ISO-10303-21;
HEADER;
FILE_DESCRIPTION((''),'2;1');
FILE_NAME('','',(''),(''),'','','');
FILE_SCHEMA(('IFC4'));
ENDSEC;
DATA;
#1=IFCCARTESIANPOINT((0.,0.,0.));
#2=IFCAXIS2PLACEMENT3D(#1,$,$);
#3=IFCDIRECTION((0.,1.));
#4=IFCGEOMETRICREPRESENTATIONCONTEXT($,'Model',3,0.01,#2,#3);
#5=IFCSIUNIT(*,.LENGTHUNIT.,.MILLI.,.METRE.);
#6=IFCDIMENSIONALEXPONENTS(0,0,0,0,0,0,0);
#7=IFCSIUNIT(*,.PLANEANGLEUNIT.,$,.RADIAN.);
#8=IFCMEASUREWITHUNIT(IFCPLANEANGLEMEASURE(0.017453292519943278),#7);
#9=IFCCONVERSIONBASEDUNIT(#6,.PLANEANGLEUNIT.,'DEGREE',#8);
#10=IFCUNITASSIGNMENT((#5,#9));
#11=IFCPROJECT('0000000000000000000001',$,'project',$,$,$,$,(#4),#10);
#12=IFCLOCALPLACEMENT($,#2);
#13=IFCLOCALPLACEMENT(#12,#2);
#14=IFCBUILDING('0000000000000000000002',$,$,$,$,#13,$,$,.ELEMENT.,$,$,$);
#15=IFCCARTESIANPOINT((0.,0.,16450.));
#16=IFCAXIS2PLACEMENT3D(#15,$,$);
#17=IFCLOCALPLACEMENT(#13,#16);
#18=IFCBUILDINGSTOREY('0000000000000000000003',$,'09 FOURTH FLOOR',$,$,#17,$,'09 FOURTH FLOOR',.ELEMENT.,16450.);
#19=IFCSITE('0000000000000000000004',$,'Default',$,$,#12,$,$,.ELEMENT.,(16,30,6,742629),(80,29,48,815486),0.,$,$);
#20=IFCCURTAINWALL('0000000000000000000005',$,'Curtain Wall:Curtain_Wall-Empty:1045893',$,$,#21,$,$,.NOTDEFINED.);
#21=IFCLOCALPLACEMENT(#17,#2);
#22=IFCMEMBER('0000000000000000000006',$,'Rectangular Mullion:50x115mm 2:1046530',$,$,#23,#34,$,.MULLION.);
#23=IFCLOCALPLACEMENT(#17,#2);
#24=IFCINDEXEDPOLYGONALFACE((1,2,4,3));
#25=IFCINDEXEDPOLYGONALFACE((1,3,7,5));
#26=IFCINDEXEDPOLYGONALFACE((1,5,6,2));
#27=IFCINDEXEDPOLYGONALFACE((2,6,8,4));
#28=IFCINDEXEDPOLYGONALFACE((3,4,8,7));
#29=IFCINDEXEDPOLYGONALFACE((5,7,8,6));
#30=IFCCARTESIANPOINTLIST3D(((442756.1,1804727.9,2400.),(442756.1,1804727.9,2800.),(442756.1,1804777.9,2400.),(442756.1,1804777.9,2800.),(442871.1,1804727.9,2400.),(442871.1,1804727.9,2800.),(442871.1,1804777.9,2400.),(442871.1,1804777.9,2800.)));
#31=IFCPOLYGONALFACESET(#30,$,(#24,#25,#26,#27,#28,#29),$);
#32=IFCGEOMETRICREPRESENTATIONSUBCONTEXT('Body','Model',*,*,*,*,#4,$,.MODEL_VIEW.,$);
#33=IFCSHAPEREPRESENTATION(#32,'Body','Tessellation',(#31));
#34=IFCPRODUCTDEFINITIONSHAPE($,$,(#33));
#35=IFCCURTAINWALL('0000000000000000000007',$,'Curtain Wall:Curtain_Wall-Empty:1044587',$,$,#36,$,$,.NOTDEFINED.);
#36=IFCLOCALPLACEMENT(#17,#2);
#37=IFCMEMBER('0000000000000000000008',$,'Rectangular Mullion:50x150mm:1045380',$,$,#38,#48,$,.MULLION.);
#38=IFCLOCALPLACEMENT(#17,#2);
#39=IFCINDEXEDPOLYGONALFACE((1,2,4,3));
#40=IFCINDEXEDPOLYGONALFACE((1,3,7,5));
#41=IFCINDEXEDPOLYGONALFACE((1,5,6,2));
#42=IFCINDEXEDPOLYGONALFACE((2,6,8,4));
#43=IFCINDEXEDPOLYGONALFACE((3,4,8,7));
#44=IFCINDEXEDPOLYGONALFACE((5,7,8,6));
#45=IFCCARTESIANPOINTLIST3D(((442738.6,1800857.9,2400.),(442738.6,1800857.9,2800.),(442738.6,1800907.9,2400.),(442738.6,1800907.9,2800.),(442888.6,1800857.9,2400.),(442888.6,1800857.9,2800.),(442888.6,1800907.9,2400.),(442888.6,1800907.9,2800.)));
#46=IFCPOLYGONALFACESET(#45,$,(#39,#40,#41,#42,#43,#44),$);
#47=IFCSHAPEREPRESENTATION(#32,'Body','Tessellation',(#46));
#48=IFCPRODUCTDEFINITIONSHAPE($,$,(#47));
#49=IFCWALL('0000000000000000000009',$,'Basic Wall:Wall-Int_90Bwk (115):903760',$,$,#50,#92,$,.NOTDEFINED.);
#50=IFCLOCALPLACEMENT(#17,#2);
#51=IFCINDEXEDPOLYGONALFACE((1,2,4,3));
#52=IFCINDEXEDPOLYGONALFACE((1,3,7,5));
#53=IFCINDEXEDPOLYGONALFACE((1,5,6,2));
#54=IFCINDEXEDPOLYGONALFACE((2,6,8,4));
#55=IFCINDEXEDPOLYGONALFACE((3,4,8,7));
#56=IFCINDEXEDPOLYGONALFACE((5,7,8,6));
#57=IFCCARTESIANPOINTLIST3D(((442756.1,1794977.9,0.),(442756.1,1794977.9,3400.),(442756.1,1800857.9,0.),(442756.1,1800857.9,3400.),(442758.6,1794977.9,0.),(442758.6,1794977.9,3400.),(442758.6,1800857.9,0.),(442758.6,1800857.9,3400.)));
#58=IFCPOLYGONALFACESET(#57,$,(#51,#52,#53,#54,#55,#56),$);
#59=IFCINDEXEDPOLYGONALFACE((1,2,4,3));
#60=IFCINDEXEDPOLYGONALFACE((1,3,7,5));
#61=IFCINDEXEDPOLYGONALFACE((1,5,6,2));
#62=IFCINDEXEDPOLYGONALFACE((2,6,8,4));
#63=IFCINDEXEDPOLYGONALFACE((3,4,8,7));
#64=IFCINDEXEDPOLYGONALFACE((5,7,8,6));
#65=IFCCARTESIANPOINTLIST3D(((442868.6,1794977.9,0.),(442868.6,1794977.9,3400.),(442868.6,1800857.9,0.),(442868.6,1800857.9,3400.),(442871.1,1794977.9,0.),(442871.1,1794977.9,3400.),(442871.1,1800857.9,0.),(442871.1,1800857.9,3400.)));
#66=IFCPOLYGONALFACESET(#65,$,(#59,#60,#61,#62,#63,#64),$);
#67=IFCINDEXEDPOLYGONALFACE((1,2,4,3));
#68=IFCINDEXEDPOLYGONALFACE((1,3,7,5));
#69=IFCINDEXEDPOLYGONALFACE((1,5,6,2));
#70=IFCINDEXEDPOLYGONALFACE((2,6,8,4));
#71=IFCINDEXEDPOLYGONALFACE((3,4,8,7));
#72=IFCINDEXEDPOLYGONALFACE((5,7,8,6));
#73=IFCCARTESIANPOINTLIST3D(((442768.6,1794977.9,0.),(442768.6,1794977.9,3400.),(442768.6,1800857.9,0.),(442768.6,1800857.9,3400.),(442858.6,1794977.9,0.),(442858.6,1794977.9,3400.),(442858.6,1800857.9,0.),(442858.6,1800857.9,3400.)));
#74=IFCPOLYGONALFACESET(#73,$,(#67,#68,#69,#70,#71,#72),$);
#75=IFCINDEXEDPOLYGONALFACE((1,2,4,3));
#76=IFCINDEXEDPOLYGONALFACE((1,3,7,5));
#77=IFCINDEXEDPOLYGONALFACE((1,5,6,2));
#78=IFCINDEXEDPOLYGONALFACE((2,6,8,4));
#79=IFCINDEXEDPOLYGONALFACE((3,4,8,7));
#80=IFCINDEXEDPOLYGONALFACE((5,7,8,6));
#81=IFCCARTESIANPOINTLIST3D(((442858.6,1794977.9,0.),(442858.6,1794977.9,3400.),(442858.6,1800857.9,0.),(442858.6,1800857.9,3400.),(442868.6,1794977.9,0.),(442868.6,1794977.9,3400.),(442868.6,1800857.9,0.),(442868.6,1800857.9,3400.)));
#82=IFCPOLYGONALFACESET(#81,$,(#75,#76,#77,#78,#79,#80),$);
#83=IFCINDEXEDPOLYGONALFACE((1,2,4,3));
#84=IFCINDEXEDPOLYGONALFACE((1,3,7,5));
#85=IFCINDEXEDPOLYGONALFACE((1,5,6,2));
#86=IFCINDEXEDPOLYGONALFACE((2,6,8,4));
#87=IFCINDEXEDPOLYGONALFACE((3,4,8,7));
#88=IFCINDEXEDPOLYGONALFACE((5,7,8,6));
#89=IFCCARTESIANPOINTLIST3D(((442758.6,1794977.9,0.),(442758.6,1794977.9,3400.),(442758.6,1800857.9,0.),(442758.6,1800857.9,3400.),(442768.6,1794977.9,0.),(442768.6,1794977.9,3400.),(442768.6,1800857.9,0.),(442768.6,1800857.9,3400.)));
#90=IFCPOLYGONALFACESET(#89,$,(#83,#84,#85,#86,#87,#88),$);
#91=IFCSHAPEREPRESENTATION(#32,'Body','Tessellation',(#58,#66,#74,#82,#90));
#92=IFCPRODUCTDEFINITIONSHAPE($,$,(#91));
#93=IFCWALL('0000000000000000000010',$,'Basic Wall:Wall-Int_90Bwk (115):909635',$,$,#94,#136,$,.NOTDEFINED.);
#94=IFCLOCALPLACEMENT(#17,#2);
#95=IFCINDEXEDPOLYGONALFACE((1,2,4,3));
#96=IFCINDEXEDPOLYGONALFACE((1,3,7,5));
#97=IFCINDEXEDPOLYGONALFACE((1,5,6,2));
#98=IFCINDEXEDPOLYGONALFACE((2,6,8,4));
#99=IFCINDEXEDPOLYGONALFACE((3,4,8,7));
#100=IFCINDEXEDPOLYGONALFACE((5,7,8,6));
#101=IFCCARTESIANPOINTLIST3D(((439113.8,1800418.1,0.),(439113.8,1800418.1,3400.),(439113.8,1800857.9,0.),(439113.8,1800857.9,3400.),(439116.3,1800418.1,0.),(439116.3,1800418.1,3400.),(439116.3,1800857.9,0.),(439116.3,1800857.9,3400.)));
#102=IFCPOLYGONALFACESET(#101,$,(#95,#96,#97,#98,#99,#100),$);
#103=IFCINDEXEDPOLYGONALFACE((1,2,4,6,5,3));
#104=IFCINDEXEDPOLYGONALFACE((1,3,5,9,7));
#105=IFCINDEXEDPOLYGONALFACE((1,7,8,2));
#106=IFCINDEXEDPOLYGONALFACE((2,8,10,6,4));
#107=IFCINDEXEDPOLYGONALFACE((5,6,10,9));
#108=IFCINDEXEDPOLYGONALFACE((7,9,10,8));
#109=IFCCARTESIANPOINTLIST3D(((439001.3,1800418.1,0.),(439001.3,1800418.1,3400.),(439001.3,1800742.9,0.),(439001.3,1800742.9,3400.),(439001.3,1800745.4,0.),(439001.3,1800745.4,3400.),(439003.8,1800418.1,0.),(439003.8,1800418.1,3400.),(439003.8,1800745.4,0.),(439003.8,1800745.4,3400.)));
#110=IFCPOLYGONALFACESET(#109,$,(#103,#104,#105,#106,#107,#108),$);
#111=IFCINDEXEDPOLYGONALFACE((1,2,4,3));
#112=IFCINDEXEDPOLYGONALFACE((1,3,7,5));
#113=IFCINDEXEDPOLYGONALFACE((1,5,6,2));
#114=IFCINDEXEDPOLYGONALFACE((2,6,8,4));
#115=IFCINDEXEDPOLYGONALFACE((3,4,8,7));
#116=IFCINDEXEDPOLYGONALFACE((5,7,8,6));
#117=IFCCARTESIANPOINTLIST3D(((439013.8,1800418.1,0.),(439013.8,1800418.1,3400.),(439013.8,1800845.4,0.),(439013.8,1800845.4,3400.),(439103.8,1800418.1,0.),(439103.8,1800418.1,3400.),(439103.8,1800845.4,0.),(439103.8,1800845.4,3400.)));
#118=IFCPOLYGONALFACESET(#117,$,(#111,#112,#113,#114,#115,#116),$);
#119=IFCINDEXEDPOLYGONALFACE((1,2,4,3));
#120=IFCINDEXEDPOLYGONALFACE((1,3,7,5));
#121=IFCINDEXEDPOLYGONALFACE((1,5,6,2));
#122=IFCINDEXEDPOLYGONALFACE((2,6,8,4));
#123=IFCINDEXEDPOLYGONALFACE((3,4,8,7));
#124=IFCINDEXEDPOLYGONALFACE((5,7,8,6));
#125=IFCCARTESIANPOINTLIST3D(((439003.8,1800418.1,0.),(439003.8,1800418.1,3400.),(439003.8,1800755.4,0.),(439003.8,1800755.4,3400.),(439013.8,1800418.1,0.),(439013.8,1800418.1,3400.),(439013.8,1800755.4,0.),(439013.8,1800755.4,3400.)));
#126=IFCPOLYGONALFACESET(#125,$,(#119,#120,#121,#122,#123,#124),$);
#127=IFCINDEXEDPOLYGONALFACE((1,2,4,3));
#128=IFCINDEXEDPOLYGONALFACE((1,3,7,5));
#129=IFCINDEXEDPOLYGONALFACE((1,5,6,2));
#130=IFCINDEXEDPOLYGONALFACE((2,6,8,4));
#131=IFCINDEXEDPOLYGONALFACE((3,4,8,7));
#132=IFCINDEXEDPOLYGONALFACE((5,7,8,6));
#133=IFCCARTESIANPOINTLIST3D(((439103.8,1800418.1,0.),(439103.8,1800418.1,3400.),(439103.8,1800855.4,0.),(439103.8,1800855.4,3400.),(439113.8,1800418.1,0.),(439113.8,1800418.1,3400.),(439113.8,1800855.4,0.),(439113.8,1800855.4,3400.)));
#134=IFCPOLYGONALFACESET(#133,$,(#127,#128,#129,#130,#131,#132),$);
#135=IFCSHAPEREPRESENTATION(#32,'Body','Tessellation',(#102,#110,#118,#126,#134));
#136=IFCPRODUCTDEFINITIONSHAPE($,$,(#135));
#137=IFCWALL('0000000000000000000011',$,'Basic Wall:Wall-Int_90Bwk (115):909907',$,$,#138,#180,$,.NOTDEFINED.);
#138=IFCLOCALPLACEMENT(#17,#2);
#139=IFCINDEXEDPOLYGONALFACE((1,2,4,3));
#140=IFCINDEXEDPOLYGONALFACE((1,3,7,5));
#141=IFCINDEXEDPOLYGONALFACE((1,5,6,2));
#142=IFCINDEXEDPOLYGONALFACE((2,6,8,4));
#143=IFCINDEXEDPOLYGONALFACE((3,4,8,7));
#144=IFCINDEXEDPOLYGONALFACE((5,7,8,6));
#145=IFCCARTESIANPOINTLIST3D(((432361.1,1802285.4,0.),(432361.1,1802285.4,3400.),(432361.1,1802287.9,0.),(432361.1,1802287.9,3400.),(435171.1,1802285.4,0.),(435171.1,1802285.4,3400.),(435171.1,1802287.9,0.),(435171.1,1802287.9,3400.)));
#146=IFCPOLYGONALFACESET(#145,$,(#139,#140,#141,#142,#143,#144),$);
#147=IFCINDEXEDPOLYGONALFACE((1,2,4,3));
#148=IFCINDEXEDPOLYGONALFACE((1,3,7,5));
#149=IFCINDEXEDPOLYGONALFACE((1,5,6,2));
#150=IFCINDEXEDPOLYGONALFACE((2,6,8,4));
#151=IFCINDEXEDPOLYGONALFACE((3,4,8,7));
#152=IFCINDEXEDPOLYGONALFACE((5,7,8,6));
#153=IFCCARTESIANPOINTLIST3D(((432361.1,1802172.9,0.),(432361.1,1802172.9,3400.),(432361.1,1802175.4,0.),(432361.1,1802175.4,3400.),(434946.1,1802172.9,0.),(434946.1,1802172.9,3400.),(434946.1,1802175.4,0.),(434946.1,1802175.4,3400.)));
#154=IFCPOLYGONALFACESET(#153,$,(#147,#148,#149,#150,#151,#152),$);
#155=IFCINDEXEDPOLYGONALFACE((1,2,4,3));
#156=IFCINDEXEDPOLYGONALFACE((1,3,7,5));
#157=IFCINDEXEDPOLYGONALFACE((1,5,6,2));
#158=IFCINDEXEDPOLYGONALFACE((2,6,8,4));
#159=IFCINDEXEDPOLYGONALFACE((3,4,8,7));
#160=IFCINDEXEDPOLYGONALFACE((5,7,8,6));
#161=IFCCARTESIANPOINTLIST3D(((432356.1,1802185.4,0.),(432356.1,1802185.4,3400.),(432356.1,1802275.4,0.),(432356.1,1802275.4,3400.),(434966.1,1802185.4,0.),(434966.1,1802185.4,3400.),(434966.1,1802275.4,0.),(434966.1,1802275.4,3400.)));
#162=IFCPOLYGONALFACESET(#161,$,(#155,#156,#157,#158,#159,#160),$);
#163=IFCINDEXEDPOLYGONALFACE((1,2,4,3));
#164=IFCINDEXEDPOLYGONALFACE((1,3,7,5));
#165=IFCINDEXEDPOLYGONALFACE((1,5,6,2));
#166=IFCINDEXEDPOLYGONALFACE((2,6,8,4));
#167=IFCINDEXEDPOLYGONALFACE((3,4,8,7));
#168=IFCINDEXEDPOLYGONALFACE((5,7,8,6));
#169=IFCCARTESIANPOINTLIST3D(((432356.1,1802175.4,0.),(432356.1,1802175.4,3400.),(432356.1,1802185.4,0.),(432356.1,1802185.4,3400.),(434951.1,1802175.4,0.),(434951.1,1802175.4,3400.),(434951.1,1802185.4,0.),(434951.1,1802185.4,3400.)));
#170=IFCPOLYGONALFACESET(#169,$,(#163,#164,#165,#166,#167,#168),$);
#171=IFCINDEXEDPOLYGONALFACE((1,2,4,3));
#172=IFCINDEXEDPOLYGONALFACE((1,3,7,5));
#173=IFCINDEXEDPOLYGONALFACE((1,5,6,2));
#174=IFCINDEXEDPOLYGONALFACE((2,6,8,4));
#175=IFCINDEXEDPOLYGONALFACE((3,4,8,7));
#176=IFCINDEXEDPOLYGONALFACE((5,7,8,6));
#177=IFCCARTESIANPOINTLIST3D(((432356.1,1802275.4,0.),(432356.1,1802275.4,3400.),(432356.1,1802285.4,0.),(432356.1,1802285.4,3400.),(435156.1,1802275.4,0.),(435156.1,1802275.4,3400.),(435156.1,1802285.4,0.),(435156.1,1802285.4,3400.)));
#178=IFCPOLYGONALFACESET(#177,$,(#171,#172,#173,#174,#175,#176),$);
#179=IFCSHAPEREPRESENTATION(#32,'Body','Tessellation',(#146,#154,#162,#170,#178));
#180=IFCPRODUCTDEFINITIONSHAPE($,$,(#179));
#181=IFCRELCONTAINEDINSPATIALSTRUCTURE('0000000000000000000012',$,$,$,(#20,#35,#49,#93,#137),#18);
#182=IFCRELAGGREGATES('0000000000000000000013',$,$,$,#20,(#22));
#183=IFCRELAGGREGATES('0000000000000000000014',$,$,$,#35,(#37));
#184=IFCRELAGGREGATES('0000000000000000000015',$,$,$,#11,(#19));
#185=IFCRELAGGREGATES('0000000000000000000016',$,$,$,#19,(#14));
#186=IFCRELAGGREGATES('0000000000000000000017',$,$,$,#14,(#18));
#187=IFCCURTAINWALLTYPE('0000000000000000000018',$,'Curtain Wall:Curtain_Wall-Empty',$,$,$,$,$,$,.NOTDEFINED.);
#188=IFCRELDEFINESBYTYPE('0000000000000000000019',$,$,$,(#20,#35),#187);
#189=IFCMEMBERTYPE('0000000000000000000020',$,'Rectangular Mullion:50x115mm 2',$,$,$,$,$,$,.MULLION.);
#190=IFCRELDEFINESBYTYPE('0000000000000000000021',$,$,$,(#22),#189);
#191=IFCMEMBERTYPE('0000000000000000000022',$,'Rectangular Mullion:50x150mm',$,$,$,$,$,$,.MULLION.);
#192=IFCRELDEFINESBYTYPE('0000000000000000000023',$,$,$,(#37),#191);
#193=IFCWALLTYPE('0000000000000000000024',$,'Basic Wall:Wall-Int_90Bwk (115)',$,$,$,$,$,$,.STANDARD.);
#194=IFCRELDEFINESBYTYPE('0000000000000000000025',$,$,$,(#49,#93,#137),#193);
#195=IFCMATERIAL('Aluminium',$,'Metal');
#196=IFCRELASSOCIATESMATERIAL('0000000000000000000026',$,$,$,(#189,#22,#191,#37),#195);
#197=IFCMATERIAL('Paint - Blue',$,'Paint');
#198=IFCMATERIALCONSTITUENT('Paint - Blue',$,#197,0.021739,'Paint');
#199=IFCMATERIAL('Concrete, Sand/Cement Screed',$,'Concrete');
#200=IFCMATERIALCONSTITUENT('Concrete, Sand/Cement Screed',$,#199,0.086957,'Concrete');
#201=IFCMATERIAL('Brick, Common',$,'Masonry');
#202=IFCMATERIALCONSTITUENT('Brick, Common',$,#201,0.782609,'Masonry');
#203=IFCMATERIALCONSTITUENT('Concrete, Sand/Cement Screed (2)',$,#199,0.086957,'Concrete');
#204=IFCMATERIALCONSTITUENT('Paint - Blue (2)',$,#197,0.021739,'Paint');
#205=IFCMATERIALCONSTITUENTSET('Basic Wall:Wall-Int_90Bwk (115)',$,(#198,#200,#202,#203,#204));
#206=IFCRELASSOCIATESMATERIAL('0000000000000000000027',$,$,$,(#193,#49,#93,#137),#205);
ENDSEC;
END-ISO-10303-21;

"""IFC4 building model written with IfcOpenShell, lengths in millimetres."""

from ifc_helpers import new_model, entity, si_unit, converted_unit, direction, frame, origin, place, context, subcontext, project, spatial, indexed_curve, outline, extrude, source, transform, mapped, material, constituent, constituent_set, type_object, type_shapes, element, aggregate, save


model = new_model("IFC4")

# Units and contexts
model_context = context("Model", 3, precision=0.01, world=origin(), true_north=direction((0.0, 1.0)))
body_context = subcontext(model_context, "Body", "Model", "MODEL_VIEW")
ifc_project = project(units=[si_unit("LENGTHUNIT", "METRE", prefix="MILLI"), converted_unit("PLANEANGLEUNIT", "DEGREE", entity("IfcPlaneAngleMeasure", 0.017453292519943278), si_unit("PLANEANGLEUNIT", "RADIAN"), dimensions=[0, 0, 0, 0, 0, 0, 0])], contexts=[model_context])

# Site, building, storey
site_placement = place(None, origin())
site = spatial("IfcSite", under=ifc_project, at=site_placement, Name="Default", CompositionType="ELEMENT", RefLatitude=(16, 30, 6, 742629), RefLongitude=(80, 29, 48, 815486), RefElevation=0.0)
building_placement = place(site_placement, origin())
building = spatial("IfcBuilding", under=site, at=building_placement, CompositionType="ELEMENT")
storey_placement = place(building_placement, frame((0.0, 0.0, 16450.0)))
storey = spatial("IfcBuildingStorey", under=building, at=storey_placement, Name="09 FOURTH FLOOR", LongName="09 FOURTH FLOOR", CompositionType="ELEMENT", Elevation=16450.0)

# Curtain walls, members
curtain_wall_type = type_object("IfcCurtainWallType", Name="Curtain Wall:Curtain_Wall-Empty", PredefinedType="NOTDEFINED")
curtain_wall_1_placement = place(storey_placement, frame((0.0, 0.0, -16450.0)))
curtain_wall_1 = element("IfcCurtainWall", 1, at=curtain_wall_1_placement, inside=storey, type_object=curtain_wall_type, Name="Curtain Wall:Curtain_Wall-Empty:1045893", PredefinedType="NOTDEFINED")
ifc_material_1 = material(Name="Aluminium", Category="Metal")
member_type_1 = type_object("IfcMemberType", Name="Rectangular Mullion:50x115mm 2", PredefinedType="MULLION", material=ifc_material_1)
shared_shape_1 = source(origin(), body_context, "Body", "SweptSolid", [
    extrude(outline(indexed_curve([(-25.0, -57.5), (25.0, -57.5), (25.0, 57.5), (-25.0, 57.5), (-25.0, -57.5)], self_intersect=False)), frame((-25.0, 0.0, -400.0), z_axis=(0.0, 0.0, 1.0), x_axis=(-1.0, 0.0, 0.0)), (0.0, 0.0, 1.0), 400.0),
])
type_shapes(member_type_1, [shared_shape_1])
member_1_placement = place(curtain_wall_1_placement, frame((442813.6, 1804727.9, 19250.0), z_axis=(0.0, 0.0, 1.0), x_axis=(0.0, -1.0, 0.0)))
member_1 = element("IfcMember", 2, at=member_1_placement, type_object=member_type_1, material=ifc_material_1, Name="Rectangular Mullion:50x115mm 2:1046530", PredefinedType="MULLION", context=body_context, shape_type="MappedRepresentation", body=[
    mapped(shared_shape_1, transform((0.0, 0.0, 0.0), scale=1.0)),
])
aggregate(curtain_wall_1, [member_1])
curtain_wall_2_placement = place(storey_placement, frame((0.0, 0.0, -16450.0)))
curtain_wall_2 = element("IfcCurtainWall", 3, at=curtain_wall_2_placement, inside=storey, type_object=curtain_wall_type, Name="Curtain Wall:Curtain_Wall-Empty:1044587", PredefinedType="NOTDEFINED")
member_type_2 = type_object("IfcMemberType", Name="Rectangular Mullion:50x150mm", PredefinedType="MULLION", material=ifc_material_1)
shared_shape_2 = source(origin(), body_context, "Body", "SweptSolid", [
    extrude(outline(indexed_curve([(-25.0, -75.0), (25.0, -75.0), (25.0, 75.0), (-25.0, 75.0), (-25.0, -75.0)], self_intersect=False)), frame((-25.0, 0.0, -400.0), z_axis=(0.0, 0.0, 1.0), x_axis=(-1.0, 0.0, 0.0)), (0.0, 0.0, 1.0), 400.0),
])
type_shapes(member_type_2, [shared_shape_2])
member_2_placement = place(curtain_wall_2_placement, frame((442813.6, 1800857.9, 19250.0), z_axis=(0.0, 0.0, 1.0), x_axis=(0.0, -1.0, 0.0)))
member_2 = element("IfcMember", 4, at=member_2_placement, type_object=member_type_2, material=ifc_material_1, Name="Rectangular Mullion:50x150mm:1045380", PredefinedType="MULLION", context=body_context, shape_type="MappedRepresentation", body=[
    mapped(shared_shape_2, transform((0.0, 0.0, 0.0), scale=1.0)),
])
aggregate(curtain_wall_2, [member_2])

# Wall
ifc_material_2 = material(Name="Paint - Blue", Category="Paint")
ifc_constituent_1 = constituent(ifc_material_2, Name="Paint - Blue", Category="Paint", fraction=0.021739)
ifc_material_3 = material(Name="Concrete, Sand/Cement Screed", Category="Concrete")
ifc_constituent_2 = constituent(ifc_material_3, Name="Concrete, Sand/Cement Screed", Category="Concrete", fraction=0.086957)
ifc_material_4 = material(Name="Brick, Common", Category="Masonry")
ifc_constituent_3 = constituent(ifc_material_4, Name="Brick, Common", Category="Masonry", fraction=0.782609)
ifc_constituent_4 = constituent(ifc_material_3, Name="Concrete, Sand/Cement Screed (2)", Category="Concrete", fraction=0.086957)
ifc_constituent_5 = constituent(ifc_material_2, Name="Paint - Blue (2)", Category="Paint", fraction=0.021739)
ifc_constituent_set_1 = constituent_set(constituents=[ifc_constituent_1, ifc_constituent_2, ifc_constituent_3, ifc_constituent_4, ifc_constituent_5], Name="Basic Wall:Wall-Int_90Bwk (115)")
wall_type_1 = type_object("IfcWallType", Name="Basic Wall:Wall-Int_90Bwk (115)", PredefinedType="STANDARD", material=ifc_constituent_set_1)
wall_1_placement = place(storey_placement, frame((442813.6, 1794977.9, 0.0), z_axis=(0.0, 0.0, 1.0), x_axis=(0.0, 1.0, 0.0)))
element("IfcWall", 5, at=wall_1_placement, inside=storey, type_object=wall_type_1, material=ifc_constituent_set_1, Name="Basic Wall:Wall-Int_90Bwk (115):903760", PredefinedType="NOTDEFINED", context=body_context, shape_type="SweptSolid", body=[
    extrude(outline(indexed_curve([(-1.3, -2940.0), (1.2, -2940.0), (1.2, 2940.0), (-1.3, 2940.0), (-1.3, -2940.0)], self_intersect=False)), frame((2940.0, 56.2, 0.0), z_axis=(0.0, 0.0, 1.0), x_axis=(0.0, -1.0, 0.0)), (0.0, 0.0, 1.0), 3400.0),
    extrude(outline(indexed_curve([(-1.3, -2940.0), (1.2, -2940.0), (1.2, 2940.0), (-1.3, 2940.0), (-1.3, -2940.0)], self_intersect=False)), frame((2940.0, -56.2, 0.0), z_axis=(0.0, 0.0, 1.0), x_axis=(0.0, 1.0, 0.0)), (0.0, 0.0, 1.0), 3400.0),
    extrude(outline(indexed_curve([(-2940.0, -45.0), (2940.0, -45.0), (2940.0, 45.0), (-2940.0, 45.0), (-2940.0, -45.0)], self_intersect=False)), frame((2940.0, 0.0, 0.0)), (0.0, 0.0, 1.0), 3400.0),
    extrude(outline(indexed_curve([(-2940.0, -5.0), (2940.0, -5.0), (2940.0, 5.0), (-2940.0, 5.0), (-2940.0, -5.0)], self_intersect=False)), frame((2940.0, -50.0, 0.0)), (0.0, 0.0, 1.0), 3400.0),
    extrude(outline(indexed_curve([(-2940.0, -5.0), (2940.0, -5.0), (2940.0, 5.0), (-2940.0, 5.0), (-2940.0, -5.0)], self_intersect=False)), frame((2940.0, 50.0, 0.0)), (0.0, 0.0, 1.0), 3400.0),
])

# Wall
wall_2_placement = place(storey_placement, frame((439058.8, 1800418.1, 0.0), z_axis=(0.0, 0.0, 1.0), x_axis=(0.0, 1.0, 0.0)))
element("IfcWall", 6, at=wall_2_placement, inside=storey, type_object=wall_type_1, material=ifc_constituent_set_1, Name="Basic Wall:Wall-Int_90Bwk (115):909635", PredefinedType="NOTDEFINED", context=body_context, shape_type="SweptSolid", body=[
    extrude(outline(indexed_curve([(-1.3, -219.9), (1.2, -219.9), (1.2, 219.9), (-1.3, 219.9), (-1.3, -219.9)], self_intersect=False)), frame((219.9, -56.2, 0.0), z_axis=(0.0, 0.0, 1.0), x_axis=(0.0, 1.0, 0.0)), (0.0, 0.0, 1.0), 3400.0),
    extrude(outline(indexed_curve([(-128.9, -1.0), (195.9, -1.0), (195.9, 1.5), (-131.4, 1.5), (-131.4, -1.0), (-128.9, -1.0)], self_intersect=False)), frame((195.9, 56.5, 0.0), z_axis=(0.0, 0.0, 1.0), x_axis=(-1.0, 0.0, 0.0)), (0.0, 0.0, 1.0), 3400.0),
    extrude(outline(indexed_curve([(-213.7, -45.0), (213.7, -45.0), (213.7, 45.0), (-213.7, 45.0), (-213.7, -45.0)], self_intersect=False)), frame((213.7, 0.0, 0.0)), (0.0, 0.0, 1.0), 3400.0),
    extrude(outline(indexed_curve([(-168.7, -5.0), (168.7, -5.0), (168.7, 5.0), (-168.7, 5.0), (-168.7, -5.0)], self_intersect=False)), frame((168.7, 50.0, 0.0)), (0.0, 0.0, 1.0), 3400.0),
    extrude(outline(indexed_curve([(-218.7, -5.0), (218.7, -5.0), (218.7, 5.0), (-218.7, 5.0), (-218.7, -5.0)], self_intersect=False)), frame((218.7, -50.0, 0.0)), (0.0, 0.0, 1.0), 3400.0),
])

# Wall
wall_3_placement = place(storey_placement, frame((432361.1, 1802230.4, 0.0)))
element("IfcWall", 7, at=wall_3_placement, inside=storey, type_object=wall_type_1, material=ifc_constituent_set_1, Name="Basic Wall:Wall-Int_90Bwk (115):909907", PredefinedType="NOTDEFINED", context=body_context, shape_type="SweptSolid", body=[
    extrude(outline(indexed_curve([(-1.3, -1405.0), (1.3, -1405.0), (1.3, 1405.0), (-1.3, 1405.0), (-1.3, -1405.0)], self_intersect=False)), frame((1405.0, 56.3, 0.0), z_axis=(0.0, 0.0, 1.0), x_axis=(0.0, -1.0, 0.0)), (0.0, 0.0, 1.0), 3400.0),
    extrude(outline(indexed_curve([(-1.2, -1292.5), (1.3, -1292.5), (1.3, 1292.5), (-1.2, 1292.5), (-1.2, -1292.5)], self_intersect=False)), frame((1292.5, -56.3, 0.0), z_axis=(0.0, 0.0, 1.0), x_axis=(0.0, 1.0, 0.0)), (0.0, 0.0, 1.0), 3400.0),
    extrude(outline(indexed_curve([(-1305.0, -45.0), (1305.0, -45.0), (1305.0, 45.0), (-1305.0, 45.0), (-1305.0, -45.0)], self_intersect=False)), frame((1300.0, 0.0, 0.0)), (0.0, 0.0, 1.0), 3400.0),
    extrude(outline(indexed_curve([(-1297.5, -5.0), (1297.5, -5.0), (1297.5, 5.0), (-1297.5, 5.0), (-1297.5, -5.0)], self_intersect=False)), frame((1292.5, -50.0, 0.0)), (0.0, 0.0, 1.0), 3400.0),
    extrude(outline(indexed_curve([(-1400.0, -5.0), (1400.0, -5.0), (1400.0, 5.0), (-1400.0, 5.0), (-1400.0, -5.0)], self_intersect=False)), frame((1395.0, 50.0, 0.0)), (0.0, 0.0, 1.0), 3400.0),
])

save(model, "model.ifc")
